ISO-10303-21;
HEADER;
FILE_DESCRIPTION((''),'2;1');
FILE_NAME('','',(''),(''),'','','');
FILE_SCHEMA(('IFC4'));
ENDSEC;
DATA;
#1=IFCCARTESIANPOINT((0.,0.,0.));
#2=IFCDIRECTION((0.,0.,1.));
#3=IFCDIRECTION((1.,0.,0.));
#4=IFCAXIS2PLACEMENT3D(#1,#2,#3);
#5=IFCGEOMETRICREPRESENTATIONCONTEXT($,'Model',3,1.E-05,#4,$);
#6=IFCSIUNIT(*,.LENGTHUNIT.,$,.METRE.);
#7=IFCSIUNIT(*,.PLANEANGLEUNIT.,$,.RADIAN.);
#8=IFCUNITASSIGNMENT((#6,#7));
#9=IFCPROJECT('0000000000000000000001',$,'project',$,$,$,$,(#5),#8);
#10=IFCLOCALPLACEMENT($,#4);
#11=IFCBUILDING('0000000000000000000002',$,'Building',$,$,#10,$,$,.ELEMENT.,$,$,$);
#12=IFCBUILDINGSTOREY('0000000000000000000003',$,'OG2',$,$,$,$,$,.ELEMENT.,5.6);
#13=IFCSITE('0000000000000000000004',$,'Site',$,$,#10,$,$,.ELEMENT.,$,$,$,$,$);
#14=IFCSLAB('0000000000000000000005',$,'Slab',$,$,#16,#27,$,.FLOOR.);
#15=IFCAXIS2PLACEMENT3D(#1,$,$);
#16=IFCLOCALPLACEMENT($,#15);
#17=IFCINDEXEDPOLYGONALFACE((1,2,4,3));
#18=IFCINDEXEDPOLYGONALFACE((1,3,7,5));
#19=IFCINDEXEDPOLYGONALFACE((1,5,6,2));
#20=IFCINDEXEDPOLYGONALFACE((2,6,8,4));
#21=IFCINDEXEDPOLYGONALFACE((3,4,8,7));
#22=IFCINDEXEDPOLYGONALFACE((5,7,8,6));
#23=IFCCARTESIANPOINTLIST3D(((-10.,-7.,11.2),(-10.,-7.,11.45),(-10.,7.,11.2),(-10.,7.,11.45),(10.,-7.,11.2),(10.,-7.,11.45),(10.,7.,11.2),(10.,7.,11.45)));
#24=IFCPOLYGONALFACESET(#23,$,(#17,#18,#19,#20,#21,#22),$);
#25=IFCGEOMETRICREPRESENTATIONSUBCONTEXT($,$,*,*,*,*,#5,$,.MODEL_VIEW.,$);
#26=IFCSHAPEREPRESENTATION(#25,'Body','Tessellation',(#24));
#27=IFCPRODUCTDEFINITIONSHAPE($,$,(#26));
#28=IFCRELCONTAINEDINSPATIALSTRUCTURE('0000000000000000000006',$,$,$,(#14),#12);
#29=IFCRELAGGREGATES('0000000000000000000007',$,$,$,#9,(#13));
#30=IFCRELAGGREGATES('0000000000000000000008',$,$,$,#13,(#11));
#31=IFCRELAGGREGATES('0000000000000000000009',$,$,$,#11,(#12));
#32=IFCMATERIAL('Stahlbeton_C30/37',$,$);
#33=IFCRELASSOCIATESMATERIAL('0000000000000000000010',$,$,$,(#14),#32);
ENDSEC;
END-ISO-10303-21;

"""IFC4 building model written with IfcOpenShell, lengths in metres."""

from ifc_helpers import new_model, si_unit, frame, frame_2d, origin, origin_with_axes, place, context, subcontext, project, spatial, rectangle, extrude, material, element, save


model = new_model("IFC4")

# Units and contexts
model_context = context("Model", 3, precision=1e-05, world=origin_with_axes())
sub_context = subcontext(model_context, None, None, "MODEL_VIEW")
ifc_project = project(units=[si_unit("LENGTHUNIT", "METRE"), si_unit("PLANEANGLEUNIT", "RADIAN")], contexts=[model_context])

# Site, building, storey
placement_1 = place(None, origin_with_axes())
site = spatial("IfcSite", under=ifc_project, at=placement_1, Name="Site", CompositionType="ELEMENT")
building = spatial("IfcBuilding", under=site, at=placement_1, Name="Building", CompositionType="ELEMENT")
storey = spatial("IfcBuildingStorey", under=building, Name="OG2", CompositionType="ELEMENT", Elevation=5.6)

# Slab
ifc_material = material(Name="Stahlbeton_C30/37")
placement_2 = place(None, origin_with_axes())
placement_3 = place(placement_2, frame((0.0, 0.0, 5.6)))
slab_placement = place(placement_3, frame((-10.0, -7.0, 5.6)))
element("IfcSlab", 1, at=slab_placement, inside=storey, material=ifc_material, Name="Slab", PredefinedType="FLOOR", context=sub_context, shape_type="SweptSolid", body=[
    extrude(rectangle(XDim=20.0, YDim=14.0, at=frame_2d((10.0, 7.0))), origin(), (0.0, 0.0, 1.0), 0.25),
])

save(model, "model.ifc")
